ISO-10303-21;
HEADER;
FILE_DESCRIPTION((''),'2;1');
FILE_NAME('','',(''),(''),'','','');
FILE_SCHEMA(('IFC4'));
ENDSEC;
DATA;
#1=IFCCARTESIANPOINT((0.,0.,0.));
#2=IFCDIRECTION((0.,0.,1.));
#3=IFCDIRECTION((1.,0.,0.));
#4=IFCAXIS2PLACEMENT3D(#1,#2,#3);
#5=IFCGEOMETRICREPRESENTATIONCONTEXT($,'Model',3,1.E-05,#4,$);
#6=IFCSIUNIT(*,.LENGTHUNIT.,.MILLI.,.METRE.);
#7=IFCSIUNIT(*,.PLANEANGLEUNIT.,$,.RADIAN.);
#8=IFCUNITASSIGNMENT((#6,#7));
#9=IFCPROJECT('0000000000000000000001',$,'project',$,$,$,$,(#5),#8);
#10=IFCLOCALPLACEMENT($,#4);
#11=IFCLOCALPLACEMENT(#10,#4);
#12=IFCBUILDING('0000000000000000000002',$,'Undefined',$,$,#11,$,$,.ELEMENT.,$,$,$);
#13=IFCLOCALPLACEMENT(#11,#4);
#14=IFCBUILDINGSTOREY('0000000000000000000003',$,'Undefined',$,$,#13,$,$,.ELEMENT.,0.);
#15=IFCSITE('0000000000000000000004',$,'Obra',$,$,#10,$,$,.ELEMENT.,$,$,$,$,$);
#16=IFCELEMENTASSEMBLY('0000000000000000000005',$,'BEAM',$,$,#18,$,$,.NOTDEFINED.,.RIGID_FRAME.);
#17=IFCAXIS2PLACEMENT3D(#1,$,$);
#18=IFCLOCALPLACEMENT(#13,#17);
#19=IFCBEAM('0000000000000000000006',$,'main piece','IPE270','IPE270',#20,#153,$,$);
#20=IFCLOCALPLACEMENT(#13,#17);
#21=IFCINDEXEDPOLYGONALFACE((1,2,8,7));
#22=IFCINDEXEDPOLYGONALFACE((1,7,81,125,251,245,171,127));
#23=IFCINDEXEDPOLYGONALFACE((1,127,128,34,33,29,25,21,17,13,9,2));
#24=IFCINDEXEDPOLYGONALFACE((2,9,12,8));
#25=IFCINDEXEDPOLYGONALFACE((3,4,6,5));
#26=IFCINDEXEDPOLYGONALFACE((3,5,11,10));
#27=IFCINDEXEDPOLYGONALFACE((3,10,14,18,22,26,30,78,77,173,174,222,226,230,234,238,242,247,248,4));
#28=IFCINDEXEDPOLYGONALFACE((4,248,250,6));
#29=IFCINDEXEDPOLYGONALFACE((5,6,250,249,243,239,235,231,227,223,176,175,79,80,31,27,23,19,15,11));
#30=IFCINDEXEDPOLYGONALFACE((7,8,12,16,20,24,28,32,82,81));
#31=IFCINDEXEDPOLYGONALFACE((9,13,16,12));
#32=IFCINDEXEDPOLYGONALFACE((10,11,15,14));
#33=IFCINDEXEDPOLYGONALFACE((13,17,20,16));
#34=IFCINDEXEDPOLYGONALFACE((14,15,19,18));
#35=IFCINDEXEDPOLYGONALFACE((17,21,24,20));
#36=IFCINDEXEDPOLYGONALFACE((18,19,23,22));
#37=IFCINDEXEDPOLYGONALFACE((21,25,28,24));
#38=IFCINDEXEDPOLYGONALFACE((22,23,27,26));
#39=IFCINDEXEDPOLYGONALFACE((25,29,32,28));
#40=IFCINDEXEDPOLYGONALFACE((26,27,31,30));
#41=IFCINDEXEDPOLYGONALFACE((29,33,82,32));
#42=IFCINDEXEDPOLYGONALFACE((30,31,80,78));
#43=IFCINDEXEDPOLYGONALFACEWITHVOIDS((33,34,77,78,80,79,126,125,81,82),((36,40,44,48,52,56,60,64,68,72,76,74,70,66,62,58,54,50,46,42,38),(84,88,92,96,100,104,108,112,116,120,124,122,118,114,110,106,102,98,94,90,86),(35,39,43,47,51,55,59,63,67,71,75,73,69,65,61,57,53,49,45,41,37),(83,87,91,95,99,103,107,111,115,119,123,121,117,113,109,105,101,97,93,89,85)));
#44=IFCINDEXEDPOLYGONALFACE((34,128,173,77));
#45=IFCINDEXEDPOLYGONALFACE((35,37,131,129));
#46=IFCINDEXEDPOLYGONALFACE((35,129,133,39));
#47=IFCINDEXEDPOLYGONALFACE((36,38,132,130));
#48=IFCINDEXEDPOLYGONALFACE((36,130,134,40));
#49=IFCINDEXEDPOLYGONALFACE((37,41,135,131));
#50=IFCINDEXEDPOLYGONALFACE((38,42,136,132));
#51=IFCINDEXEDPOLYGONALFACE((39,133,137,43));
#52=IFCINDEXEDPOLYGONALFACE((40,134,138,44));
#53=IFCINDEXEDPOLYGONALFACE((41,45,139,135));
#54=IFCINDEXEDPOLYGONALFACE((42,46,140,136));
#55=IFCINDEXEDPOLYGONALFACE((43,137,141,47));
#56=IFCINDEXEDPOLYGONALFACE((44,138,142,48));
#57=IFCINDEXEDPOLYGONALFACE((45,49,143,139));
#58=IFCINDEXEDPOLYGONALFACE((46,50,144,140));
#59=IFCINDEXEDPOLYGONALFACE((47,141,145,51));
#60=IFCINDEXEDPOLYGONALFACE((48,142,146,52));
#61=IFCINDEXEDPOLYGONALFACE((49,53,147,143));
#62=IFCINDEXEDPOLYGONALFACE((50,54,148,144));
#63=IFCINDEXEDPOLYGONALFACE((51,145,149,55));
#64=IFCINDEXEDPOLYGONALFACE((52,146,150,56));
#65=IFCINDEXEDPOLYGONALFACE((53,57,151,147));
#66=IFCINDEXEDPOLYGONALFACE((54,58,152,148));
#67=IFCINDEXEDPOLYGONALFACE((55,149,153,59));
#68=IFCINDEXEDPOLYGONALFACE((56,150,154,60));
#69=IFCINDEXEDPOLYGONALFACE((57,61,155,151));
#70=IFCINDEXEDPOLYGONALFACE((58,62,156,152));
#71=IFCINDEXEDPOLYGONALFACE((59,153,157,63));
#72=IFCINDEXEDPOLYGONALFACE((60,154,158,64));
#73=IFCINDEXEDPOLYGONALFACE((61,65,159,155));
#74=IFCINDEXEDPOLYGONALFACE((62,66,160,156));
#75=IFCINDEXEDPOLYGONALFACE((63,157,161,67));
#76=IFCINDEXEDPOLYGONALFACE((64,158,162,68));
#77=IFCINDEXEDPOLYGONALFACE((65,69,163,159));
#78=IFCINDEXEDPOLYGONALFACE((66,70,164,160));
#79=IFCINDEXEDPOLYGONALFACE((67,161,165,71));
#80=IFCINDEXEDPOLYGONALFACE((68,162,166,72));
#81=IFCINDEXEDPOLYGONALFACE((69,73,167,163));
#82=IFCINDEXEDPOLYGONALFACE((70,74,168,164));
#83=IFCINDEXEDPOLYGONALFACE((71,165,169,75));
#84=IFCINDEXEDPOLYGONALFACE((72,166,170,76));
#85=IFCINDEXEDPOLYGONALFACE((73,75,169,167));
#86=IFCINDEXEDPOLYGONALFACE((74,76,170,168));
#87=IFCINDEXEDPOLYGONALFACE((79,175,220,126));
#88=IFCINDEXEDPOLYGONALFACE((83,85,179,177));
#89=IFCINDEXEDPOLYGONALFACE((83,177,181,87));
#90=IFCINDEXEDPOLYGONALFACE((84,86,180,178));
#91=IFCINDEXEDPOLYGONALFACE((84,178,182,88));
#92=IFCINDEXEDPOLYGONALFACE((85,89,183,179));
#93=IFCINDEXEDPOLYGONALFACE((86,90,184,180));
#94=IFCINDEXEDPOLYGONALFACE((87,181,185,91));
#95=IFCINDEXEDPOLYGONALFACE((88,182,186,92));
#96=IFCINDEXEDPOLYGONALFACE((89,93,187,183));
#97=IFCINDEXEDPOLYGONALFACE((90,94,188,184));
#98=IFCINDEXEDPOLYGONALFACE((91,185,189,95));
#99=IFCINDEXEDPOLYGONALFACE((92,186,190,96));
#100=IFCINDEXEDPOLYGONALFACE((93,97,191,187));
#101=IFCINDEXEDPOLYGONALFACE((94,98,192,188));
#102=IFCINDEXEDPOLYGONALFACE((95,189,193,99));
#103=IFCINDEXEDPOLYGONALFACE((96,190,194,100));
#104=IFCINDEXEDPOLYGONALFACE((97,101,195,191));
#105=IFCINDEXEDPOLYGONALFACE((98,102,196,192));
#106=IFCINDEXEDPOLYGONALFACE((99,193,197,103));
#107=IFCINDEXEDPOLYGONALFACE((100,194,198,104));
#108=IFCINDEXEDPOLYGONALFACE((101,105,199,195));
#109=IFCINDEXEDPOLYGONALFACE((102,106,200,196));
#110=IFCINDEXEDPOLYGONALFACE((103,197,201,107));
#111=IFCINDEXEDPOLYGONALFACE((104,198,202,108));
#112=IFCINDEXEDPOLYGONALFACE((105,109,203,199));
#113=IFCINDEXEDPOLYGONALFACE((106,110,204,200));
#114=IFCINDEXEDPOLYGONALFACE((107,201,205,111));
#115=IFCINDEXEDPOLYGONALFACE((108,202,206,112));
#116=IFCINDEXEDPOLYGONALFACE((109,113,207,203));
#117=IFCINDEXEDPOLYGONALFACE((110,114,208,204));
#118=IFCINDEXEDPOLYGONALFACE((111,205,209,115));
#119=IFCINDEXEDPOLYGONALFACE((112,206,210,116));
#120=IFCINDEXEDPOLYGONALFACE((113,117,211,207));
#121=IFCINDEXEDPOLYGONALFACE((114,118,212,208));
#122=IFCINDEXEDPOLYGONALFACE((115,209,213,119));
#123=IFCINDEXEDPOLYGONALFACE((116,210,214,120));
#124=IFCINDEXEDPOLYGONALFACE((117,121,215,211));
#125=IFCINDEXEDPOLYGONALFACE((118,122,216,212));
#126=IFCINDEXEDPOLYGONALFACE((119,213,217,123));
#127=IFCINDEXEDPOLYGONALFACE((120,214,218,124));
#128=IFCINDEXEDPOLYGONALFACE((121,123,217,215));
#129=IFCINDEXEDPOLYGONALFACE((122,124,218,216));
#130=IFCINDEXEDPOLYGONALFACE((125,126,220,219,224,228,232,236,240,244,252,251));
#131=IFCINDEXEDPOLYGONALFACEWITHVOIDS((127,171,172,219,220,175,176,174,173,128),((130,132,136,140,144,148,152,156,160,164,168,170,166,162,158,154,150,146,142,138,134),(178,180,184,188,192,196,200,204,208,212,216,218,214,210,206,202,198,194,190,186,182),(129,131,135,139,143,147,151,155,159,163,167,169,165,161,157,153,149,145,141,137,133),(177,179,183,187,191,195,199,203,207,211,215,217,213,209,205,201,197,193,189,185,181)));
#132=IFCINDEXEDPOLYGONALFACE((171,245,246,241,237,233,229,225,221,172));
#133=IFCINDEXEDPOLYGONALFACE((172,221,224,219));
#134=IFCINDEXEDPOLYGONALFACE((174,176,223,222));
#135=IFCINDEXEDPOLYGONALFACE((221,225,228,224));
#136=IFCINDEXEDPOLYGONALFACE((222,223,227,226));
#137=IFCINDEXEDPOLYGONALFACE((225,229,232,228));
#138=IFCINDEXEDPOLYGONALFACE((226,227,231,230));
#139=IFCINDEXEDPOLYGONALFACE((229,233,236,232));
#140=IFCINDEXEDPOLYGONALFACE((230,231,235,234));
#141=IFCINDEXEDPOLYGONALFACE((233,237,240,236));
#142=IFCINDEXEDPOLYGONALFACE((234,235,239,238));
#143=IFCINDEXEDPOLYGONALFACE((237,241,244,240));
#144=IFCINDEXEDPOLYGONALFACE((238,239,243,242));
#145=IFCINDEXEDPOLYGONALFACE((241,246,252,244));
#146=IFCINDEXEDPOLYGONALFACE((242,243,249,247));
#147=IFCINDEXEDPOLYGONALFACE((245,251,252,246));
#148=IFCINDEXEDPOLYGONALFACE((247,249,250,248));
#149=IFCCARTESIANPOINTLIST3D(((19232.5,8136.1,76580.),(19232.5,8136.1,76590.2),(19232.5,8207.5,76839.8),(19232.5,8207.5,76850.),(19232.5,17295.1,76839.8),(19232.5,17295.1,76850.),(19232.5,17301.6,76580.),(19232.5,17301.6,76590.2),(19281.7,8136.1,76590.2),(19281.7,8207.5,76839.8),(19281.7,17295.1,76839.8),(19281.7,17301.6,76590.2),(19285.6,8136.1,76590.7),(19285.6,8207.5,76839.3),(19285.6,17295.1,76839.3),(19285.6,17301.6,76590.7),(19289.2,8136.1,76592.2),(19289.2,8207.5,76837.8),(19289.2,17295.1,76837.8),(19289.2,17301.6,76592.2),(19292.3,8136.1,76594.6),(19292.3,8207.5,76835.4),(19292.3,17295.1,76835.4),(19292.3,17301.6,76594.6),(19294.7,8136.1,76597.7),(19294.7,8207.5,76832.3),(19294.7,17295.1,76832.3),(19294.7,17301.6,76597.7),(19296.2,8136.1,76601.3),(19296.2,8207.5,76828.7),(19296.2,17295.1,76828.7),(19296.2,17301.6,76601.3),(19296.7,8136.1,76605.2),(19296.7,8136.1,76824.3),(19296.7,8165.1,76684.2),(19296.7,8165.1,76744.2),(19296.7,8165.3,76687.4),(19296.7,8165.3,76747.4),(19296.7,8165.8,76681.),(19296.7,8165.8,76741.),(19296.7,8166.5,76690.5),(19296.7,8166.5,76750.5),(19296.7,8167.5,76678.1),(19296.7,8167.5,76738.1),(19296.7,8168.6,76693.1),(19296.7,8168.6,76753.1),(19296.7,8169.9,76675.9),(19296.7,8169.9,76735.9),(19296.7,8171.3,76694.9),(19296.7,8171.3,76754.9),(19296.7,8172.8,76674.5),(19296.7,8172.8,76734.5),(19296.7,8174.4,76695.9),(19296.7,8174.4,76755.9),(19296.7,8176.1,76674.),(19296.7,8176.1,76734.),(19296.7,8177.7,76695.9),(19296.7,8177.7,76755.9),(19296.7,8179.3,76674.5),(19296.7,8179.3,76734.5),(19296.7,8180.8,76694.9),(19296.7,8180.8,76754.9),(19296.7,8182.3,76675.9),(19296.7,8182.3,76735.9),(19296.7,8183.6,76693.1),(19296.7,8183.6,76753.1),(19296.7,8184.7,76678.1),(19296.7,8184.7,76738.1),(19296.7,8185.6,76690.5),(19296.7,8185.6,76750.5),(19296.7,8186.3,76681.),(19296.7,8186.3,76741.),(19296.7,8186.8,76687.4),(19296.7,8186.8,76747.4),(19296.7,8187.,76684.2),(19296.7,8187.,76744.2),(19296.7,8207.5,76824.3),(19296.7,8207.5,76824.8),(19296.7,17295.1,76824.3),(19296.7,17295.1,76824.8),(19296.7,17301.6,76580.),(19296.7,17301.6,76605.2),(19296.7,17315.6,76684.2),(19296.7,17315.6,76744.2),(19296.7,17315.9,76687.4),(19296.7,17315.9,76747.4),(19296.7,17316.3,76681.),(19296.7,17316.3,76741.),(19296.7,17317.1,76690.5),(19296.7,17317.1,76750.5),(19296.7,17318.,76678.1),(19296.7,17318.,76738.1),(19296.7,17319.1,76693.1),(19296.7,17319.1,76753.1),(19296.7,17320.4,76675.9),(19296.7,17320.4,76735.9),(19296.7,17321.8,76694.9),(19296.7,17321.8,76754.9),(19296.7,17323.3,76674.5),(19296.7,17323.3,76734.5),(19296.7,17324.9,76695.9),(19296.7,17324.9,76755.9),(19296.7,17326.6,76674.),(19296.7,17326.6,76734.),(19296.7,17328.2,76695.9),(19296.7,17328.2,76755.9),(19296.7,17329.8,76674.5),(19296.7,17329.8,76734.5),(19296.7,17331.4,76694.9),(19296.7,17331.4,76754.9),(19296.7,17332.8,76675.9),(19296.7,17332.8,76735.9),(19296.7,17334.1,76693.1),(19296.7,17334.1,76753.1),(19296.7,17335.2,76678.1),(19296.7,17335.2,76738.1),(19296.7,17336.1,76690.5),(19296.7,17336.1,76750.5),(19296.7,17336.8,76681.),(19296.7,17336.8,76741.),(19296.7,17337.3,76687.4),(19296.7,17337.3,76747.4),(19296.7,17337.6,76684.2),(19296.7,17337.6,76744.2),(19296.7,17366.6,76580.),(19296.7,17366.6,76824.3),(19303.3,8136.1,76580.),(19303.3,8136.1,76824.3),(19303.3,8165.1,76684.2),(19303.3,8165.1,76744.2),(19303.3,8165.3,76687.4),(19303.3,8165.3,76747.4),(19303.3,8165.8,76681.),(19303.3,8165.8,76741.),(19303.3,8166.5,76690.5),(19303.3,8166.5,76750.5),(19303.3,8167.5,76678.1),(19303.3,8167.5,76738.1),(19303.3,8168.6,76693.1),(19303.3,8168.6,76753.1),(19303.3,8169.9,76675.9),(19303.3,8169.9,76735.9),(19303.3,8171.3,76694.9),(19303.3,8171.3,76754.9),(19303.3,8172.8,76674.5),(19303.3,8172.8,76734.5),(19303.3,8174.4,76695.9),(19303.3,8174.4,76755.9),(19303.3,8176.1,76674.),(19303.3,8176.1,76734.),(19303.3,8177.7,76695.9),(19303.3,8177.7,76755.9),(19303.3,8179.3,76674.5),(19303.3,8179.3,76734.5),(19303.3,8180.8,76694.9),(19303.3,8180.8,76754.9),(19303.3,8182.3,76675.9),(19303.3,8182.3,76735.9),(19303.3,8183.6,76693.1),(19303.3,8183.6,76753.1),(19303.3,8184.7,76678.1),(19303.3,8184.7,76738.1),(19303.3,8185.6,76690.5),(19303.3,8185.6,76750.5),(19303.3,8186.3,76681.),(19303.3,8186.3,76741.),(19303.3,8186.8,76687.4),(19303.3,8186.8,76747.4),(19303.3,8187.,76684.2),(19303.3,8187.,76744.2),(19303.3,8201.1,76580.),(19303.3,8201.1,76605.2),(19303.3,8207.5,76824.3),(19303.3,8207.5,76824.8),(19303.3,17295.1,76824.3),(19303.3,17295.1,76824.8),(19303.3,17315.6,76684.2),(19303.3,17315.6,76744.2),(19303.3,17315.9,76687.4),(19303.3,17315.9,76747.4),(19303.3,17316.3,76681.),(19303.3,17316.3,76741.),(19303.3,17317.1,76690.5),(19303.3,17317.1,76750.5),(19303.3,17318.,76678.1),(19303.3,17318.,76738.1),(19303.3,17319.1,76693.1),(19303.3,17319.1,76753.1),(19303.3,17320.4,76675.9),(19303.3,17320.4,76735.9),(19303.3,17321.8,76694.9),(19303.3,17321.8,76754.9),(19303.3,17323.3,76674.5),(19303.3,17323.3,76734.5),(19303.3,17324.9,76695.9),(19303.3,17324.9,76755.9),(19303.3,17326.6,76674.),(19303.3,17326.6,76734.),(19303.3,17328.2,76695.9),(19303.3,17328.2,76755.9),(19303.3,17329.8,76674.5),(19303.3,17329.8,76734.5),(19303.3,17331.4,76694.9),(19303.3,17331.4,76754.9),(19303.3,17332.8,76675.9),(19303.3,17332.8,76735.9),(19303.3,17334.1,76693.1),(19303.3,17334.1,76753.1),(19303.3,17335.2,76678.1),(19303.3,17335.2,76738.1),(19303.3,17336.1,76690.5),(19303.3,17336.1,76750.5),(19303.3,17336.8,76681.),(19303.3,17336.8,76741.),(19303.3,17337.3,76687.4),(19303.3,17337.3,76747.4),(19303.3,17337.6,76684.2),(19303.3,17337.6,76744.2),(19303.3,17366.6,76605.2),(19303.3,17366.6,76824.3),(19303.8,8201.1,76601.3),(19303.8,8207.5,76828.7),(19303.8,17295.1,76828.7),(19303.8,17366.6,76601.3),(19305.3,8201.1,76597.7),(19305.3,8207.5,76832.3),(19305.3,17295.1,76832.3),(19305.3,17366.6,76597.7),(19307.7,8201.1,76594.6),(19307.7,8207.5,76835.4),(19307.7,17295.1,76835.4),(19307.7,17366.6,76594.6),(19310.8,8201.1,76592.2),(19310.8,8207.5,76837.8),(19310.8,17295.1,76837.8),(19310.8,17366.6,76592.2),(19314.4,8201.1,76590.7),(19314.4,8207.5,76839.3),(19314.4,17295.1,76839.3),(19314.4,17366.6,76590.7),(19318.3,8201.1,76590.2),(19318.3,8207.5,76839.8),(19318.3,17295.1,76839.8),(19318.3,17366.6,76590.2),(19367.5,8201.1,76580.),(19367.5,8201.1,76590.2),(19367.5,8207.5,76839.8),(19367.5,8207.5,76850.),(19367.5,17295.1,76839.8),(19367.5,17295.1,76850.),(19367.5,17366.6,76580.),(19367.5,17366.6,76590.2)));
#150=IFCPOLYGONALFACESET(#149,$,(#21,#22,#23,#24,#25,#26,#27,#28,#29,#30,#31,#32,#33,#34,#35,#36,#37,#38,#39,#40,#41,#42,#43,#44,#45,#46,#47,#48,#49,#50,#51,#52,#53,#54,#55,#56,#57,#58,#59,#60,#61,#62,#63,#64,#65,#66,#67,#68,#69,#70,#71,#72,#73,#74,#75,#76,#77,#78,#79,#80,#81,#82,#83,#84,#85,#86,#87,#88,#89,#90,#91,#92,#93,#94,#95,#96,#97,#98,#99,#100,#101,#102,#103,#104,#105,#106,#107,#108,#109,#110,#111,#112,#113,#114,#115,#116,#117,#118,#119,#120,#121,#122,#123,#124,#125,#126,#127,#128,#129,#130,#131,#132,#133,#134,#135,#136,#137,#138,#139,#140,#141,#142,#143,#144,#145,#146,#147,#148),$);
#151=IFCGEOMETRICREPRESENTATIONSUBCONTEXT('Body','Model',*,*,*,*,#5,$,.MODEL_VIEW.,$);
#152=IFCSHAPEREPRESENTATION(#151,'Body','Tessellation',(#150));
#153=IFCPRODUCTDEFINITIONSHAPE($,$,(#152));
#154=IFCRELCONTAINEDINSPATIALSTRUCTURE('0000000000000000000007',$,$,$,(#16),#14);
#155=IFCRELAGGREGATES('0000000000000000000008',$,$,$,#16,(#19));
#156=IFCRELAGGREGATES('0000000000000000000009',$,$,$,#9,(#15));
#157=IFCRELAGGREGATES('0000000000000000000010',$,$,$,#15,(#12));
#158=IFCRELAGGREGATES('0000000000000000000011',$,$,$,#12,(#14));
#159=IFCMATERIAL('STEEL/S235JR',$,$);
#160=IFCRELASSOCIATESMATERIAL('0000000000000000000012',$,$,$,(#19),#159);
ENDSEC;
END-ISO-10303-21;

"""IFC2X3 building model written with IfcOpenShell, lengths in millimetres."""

from ifc_helpers import new_model, si_unit, frame, origin_with_axes, origin_2d_with_axis, place, context, subcontext, project, spatial, rectangle, circle, i_section, extrude, clip, halfspace, source, transform, mapped, material, element, aggregate, save


model = new_model("IFC2X3")

# Units and contexts
model_context = context("Model", 3, precision=1e-05, world=origin_with_axes())
body_context = subcontext(model_context, "Body", "Model", "MODEL_VIEW")
ifc_project = project(units=[si_unit("LENGTHUNIT", "METRE", prefix="MILLI"), si_unit("PLANEANGLEUNIT", "RADIAN")], contexts=[model_context])

# Site, building, storey
site_placement = place(None, origin_with_axes())
site = spatial("IfcSite", under=ifc_project, at=site_placement, Name="Obra", CompositionType="ELEMENT")
building_placement = place(site_placement, origin_with_axes())
building = spatial("IfcBuilding", under=site, at=building_placement, Name="Undefined", CompositionType="ELEMENT")
storey_placement = place(building_placement, origin_with_axes())
storey = spatial("IfcBuildingStorey", under=building, at=storey_placement, Name="Undefined", CompositionType="ELEMENT", Elevation=0.0)

# Shared definitions
ifc_material = material(Name="STEEL/S235JR")

# Element assembly, beam, openings
shared_shape_1 = source(origin_with_axes(), body_context, "Body", "SweptSolid", [
    extrude(circle(Radius=11.0, at=origin_2d_with_axis()), frame((0.0, -3.4, 0.0), z_axis=(0.0, 1.0, 0.0), x_axis=(1.0, 0.0, 0.0)), (0.0, 0.0, 1.0), 6.8),
])
assembly_1_placement = place(storey_placement, origin_with_axes())
assembly_1 = element("IfcElementAssembly", 1, at=assembly_1_placement, inside=storey, Name="BEAM", AssemblyPlace="NOTDEFINED", PredefinedType="RIGID_FRAME")
beam_1_placement = place(assembly_1_placement, frame((19300.0, 8217.5, 76715.0), z_axis=(0.0, 0.0, 1.0), x_axis=(0.0, 1.0, 0.0)))
beam_1 = element("IfcBeam", 2, at=beam_1_placement, material=ifc_material, Name="main piece", Description="IPE270", ObjectType="IPE270", context=body_context, shape_type="Clipping", body=[
    clip(clip(extrude(i_section(OverallWidth=135.0, OverallDepth=270.0, WebThickness=6.6, FlangeThickness=10.2, FilletRadius=15.0, at=origin_2d_with_axis()), frame((9149.1, 0.0, 0.0), z_axis=(-1.0, 0.0, 0.0), x_axis=(0.0, -1.0, 0.0)), (0.0, 0.0, 1.0), 9230.5), halfspace(frame((9149.1, 0.0, -235.0), z_axis=(-1.0, 0.0, 0.0), x_axis=(0.0, 1.0, 0.0)), True)), halfspace(frame((-81.4, 0.0, -235.0), z_axis=(1.0, 0.0, 0.0), x_axis=(0.0, -1.0, 0.0)), True)),
])
opening_1_placement = place(assembly_1_placement, frame((19300.0, 8217.5, 76715.0), z_axis=(0.0, 0.0, 1.0), x_axis=(0.0, 1.0, 0.0)))
element("IfcOpeningElement", 3, at=opening_1_placement, cuts=beam_1, ObjectType="Recess", context=body_context, shape_type="SweptSolid", body=[
    extrude(rectangle(XDim=75.0, YDim=300.0, at=origin_2d_with_axis()), frame((9121.6, 153.3, 124.3), z_axis=(0.0, 0.0, -1.0), x_axis=(-1.0, 0.0, 0.0)), (0.0, 0.0, 1.0), 278.6),
])
opening_2_placement = place(assembly_1_placement, frame((19300.0, 8217.5, 76715.0), z_axis=(0.0, 0.0, 1.0), x_axis=(0.0, 1.0, 0.0)))
element("IfcOpeningElement", 4, at=opening_2_placement, cuts=beam_1, ObjectType="Recess", context=body_context, shape_type="SweptSolid", body=[
    extrude(rectangle(XDim=26.7, YDim=83.5, at=origin_2d_with_axis()), frame((9119.3, 68.5, 122.7), z_axis=(0.0, -1.0, 0.0), x_axis=(0.0, 0.0, -1.0)), (0.0, 0.0, 1.0), 137.0),
])
opening_3_placement = place(assembly_1_placement, frame((19300.0, 8217.5, 76715.0), z_axis=(0.0, 0.0, 1.0), x_axis=(0.0, 1.0, 0.0)))
element("IfcOpeningElement", 5, at=opening_3_placement, cuts=beam_1, ObjectType="Recess", context=body_context, shape_type="SweptSolid", body=[
    extrude(rectangle(XDim=75.0, YDim=300.0, at=origin_2d_with_axis()), frame((-53.9, -153.3, 124.3), z_axis=(0.0, 0.0, -1.0), x_axis=(1.0, 0.0, 0.0)), (0.0, 0.0, 1.0), 278.6),
])
opening_4_placement = place(assembly_1_placement, frame((19300.0, 8217.5, 76715.0), z_axis=(0.0, 0.0, 1.0), x_axis=(0.0, 1.0, 0.0)))
element("IfcOpeningElement", 6, at=opening_4_placement, cuts=beam_1, ObjectType="Recess", context=body_context, shape_type="SweptSolid", body=[
    extrude(rectangle(XDim=26.7, YDim=83.5, at=origin_2d_with_axis()), frame((-51.7, -68.5, 122.7), z_axis=(0.0, 1.0, 0.0), x_axis=(0.0, 0.0, -1.0)), (0.0, 0.0, 1.0), 137.0),
])
opening_5_placement = place(assembly_1_placement, frame((19300.0, 17366.6, 76850.0), z_axis=(0.0, -1.0, 0.0), x_axis=(0.0, 0.0, -1.0)))
element("IfcOpeningElement", 7, at=opening_5_placement, cuts=beam_1, ObjectType="Opening", context=body_context, shape_type="MappedRepresentation", body=[
    mapped(shared_shape_1, transform((105.0, 0.0, 40.0))),
    mapped(shared_shape_1, transform((165.0, 0.0, 40.0))),
])
opening_6_placement = place(assembly_1_placement, frame((19300.0, 8136.1, 76850.0), z_axis=(0.0, 1.0, 0.0), x_axis=(0.0, 0.0, -1.0)))
element("IfcOpeningElement", 8, at=opening_6_placement, cuts=beam_1, ObjectType="Opening", context=body_context, shape_type="MappedRepresentation", body=[
    mapped(shared_shape_1, transform((105.0, 0.0, 40.0))),
    mapped(shared_shape_1, transform((165.0, 0.0, 40.0))),
])
aggregate(assembly_1, [beam_1])

save(model, "model.ifc")
